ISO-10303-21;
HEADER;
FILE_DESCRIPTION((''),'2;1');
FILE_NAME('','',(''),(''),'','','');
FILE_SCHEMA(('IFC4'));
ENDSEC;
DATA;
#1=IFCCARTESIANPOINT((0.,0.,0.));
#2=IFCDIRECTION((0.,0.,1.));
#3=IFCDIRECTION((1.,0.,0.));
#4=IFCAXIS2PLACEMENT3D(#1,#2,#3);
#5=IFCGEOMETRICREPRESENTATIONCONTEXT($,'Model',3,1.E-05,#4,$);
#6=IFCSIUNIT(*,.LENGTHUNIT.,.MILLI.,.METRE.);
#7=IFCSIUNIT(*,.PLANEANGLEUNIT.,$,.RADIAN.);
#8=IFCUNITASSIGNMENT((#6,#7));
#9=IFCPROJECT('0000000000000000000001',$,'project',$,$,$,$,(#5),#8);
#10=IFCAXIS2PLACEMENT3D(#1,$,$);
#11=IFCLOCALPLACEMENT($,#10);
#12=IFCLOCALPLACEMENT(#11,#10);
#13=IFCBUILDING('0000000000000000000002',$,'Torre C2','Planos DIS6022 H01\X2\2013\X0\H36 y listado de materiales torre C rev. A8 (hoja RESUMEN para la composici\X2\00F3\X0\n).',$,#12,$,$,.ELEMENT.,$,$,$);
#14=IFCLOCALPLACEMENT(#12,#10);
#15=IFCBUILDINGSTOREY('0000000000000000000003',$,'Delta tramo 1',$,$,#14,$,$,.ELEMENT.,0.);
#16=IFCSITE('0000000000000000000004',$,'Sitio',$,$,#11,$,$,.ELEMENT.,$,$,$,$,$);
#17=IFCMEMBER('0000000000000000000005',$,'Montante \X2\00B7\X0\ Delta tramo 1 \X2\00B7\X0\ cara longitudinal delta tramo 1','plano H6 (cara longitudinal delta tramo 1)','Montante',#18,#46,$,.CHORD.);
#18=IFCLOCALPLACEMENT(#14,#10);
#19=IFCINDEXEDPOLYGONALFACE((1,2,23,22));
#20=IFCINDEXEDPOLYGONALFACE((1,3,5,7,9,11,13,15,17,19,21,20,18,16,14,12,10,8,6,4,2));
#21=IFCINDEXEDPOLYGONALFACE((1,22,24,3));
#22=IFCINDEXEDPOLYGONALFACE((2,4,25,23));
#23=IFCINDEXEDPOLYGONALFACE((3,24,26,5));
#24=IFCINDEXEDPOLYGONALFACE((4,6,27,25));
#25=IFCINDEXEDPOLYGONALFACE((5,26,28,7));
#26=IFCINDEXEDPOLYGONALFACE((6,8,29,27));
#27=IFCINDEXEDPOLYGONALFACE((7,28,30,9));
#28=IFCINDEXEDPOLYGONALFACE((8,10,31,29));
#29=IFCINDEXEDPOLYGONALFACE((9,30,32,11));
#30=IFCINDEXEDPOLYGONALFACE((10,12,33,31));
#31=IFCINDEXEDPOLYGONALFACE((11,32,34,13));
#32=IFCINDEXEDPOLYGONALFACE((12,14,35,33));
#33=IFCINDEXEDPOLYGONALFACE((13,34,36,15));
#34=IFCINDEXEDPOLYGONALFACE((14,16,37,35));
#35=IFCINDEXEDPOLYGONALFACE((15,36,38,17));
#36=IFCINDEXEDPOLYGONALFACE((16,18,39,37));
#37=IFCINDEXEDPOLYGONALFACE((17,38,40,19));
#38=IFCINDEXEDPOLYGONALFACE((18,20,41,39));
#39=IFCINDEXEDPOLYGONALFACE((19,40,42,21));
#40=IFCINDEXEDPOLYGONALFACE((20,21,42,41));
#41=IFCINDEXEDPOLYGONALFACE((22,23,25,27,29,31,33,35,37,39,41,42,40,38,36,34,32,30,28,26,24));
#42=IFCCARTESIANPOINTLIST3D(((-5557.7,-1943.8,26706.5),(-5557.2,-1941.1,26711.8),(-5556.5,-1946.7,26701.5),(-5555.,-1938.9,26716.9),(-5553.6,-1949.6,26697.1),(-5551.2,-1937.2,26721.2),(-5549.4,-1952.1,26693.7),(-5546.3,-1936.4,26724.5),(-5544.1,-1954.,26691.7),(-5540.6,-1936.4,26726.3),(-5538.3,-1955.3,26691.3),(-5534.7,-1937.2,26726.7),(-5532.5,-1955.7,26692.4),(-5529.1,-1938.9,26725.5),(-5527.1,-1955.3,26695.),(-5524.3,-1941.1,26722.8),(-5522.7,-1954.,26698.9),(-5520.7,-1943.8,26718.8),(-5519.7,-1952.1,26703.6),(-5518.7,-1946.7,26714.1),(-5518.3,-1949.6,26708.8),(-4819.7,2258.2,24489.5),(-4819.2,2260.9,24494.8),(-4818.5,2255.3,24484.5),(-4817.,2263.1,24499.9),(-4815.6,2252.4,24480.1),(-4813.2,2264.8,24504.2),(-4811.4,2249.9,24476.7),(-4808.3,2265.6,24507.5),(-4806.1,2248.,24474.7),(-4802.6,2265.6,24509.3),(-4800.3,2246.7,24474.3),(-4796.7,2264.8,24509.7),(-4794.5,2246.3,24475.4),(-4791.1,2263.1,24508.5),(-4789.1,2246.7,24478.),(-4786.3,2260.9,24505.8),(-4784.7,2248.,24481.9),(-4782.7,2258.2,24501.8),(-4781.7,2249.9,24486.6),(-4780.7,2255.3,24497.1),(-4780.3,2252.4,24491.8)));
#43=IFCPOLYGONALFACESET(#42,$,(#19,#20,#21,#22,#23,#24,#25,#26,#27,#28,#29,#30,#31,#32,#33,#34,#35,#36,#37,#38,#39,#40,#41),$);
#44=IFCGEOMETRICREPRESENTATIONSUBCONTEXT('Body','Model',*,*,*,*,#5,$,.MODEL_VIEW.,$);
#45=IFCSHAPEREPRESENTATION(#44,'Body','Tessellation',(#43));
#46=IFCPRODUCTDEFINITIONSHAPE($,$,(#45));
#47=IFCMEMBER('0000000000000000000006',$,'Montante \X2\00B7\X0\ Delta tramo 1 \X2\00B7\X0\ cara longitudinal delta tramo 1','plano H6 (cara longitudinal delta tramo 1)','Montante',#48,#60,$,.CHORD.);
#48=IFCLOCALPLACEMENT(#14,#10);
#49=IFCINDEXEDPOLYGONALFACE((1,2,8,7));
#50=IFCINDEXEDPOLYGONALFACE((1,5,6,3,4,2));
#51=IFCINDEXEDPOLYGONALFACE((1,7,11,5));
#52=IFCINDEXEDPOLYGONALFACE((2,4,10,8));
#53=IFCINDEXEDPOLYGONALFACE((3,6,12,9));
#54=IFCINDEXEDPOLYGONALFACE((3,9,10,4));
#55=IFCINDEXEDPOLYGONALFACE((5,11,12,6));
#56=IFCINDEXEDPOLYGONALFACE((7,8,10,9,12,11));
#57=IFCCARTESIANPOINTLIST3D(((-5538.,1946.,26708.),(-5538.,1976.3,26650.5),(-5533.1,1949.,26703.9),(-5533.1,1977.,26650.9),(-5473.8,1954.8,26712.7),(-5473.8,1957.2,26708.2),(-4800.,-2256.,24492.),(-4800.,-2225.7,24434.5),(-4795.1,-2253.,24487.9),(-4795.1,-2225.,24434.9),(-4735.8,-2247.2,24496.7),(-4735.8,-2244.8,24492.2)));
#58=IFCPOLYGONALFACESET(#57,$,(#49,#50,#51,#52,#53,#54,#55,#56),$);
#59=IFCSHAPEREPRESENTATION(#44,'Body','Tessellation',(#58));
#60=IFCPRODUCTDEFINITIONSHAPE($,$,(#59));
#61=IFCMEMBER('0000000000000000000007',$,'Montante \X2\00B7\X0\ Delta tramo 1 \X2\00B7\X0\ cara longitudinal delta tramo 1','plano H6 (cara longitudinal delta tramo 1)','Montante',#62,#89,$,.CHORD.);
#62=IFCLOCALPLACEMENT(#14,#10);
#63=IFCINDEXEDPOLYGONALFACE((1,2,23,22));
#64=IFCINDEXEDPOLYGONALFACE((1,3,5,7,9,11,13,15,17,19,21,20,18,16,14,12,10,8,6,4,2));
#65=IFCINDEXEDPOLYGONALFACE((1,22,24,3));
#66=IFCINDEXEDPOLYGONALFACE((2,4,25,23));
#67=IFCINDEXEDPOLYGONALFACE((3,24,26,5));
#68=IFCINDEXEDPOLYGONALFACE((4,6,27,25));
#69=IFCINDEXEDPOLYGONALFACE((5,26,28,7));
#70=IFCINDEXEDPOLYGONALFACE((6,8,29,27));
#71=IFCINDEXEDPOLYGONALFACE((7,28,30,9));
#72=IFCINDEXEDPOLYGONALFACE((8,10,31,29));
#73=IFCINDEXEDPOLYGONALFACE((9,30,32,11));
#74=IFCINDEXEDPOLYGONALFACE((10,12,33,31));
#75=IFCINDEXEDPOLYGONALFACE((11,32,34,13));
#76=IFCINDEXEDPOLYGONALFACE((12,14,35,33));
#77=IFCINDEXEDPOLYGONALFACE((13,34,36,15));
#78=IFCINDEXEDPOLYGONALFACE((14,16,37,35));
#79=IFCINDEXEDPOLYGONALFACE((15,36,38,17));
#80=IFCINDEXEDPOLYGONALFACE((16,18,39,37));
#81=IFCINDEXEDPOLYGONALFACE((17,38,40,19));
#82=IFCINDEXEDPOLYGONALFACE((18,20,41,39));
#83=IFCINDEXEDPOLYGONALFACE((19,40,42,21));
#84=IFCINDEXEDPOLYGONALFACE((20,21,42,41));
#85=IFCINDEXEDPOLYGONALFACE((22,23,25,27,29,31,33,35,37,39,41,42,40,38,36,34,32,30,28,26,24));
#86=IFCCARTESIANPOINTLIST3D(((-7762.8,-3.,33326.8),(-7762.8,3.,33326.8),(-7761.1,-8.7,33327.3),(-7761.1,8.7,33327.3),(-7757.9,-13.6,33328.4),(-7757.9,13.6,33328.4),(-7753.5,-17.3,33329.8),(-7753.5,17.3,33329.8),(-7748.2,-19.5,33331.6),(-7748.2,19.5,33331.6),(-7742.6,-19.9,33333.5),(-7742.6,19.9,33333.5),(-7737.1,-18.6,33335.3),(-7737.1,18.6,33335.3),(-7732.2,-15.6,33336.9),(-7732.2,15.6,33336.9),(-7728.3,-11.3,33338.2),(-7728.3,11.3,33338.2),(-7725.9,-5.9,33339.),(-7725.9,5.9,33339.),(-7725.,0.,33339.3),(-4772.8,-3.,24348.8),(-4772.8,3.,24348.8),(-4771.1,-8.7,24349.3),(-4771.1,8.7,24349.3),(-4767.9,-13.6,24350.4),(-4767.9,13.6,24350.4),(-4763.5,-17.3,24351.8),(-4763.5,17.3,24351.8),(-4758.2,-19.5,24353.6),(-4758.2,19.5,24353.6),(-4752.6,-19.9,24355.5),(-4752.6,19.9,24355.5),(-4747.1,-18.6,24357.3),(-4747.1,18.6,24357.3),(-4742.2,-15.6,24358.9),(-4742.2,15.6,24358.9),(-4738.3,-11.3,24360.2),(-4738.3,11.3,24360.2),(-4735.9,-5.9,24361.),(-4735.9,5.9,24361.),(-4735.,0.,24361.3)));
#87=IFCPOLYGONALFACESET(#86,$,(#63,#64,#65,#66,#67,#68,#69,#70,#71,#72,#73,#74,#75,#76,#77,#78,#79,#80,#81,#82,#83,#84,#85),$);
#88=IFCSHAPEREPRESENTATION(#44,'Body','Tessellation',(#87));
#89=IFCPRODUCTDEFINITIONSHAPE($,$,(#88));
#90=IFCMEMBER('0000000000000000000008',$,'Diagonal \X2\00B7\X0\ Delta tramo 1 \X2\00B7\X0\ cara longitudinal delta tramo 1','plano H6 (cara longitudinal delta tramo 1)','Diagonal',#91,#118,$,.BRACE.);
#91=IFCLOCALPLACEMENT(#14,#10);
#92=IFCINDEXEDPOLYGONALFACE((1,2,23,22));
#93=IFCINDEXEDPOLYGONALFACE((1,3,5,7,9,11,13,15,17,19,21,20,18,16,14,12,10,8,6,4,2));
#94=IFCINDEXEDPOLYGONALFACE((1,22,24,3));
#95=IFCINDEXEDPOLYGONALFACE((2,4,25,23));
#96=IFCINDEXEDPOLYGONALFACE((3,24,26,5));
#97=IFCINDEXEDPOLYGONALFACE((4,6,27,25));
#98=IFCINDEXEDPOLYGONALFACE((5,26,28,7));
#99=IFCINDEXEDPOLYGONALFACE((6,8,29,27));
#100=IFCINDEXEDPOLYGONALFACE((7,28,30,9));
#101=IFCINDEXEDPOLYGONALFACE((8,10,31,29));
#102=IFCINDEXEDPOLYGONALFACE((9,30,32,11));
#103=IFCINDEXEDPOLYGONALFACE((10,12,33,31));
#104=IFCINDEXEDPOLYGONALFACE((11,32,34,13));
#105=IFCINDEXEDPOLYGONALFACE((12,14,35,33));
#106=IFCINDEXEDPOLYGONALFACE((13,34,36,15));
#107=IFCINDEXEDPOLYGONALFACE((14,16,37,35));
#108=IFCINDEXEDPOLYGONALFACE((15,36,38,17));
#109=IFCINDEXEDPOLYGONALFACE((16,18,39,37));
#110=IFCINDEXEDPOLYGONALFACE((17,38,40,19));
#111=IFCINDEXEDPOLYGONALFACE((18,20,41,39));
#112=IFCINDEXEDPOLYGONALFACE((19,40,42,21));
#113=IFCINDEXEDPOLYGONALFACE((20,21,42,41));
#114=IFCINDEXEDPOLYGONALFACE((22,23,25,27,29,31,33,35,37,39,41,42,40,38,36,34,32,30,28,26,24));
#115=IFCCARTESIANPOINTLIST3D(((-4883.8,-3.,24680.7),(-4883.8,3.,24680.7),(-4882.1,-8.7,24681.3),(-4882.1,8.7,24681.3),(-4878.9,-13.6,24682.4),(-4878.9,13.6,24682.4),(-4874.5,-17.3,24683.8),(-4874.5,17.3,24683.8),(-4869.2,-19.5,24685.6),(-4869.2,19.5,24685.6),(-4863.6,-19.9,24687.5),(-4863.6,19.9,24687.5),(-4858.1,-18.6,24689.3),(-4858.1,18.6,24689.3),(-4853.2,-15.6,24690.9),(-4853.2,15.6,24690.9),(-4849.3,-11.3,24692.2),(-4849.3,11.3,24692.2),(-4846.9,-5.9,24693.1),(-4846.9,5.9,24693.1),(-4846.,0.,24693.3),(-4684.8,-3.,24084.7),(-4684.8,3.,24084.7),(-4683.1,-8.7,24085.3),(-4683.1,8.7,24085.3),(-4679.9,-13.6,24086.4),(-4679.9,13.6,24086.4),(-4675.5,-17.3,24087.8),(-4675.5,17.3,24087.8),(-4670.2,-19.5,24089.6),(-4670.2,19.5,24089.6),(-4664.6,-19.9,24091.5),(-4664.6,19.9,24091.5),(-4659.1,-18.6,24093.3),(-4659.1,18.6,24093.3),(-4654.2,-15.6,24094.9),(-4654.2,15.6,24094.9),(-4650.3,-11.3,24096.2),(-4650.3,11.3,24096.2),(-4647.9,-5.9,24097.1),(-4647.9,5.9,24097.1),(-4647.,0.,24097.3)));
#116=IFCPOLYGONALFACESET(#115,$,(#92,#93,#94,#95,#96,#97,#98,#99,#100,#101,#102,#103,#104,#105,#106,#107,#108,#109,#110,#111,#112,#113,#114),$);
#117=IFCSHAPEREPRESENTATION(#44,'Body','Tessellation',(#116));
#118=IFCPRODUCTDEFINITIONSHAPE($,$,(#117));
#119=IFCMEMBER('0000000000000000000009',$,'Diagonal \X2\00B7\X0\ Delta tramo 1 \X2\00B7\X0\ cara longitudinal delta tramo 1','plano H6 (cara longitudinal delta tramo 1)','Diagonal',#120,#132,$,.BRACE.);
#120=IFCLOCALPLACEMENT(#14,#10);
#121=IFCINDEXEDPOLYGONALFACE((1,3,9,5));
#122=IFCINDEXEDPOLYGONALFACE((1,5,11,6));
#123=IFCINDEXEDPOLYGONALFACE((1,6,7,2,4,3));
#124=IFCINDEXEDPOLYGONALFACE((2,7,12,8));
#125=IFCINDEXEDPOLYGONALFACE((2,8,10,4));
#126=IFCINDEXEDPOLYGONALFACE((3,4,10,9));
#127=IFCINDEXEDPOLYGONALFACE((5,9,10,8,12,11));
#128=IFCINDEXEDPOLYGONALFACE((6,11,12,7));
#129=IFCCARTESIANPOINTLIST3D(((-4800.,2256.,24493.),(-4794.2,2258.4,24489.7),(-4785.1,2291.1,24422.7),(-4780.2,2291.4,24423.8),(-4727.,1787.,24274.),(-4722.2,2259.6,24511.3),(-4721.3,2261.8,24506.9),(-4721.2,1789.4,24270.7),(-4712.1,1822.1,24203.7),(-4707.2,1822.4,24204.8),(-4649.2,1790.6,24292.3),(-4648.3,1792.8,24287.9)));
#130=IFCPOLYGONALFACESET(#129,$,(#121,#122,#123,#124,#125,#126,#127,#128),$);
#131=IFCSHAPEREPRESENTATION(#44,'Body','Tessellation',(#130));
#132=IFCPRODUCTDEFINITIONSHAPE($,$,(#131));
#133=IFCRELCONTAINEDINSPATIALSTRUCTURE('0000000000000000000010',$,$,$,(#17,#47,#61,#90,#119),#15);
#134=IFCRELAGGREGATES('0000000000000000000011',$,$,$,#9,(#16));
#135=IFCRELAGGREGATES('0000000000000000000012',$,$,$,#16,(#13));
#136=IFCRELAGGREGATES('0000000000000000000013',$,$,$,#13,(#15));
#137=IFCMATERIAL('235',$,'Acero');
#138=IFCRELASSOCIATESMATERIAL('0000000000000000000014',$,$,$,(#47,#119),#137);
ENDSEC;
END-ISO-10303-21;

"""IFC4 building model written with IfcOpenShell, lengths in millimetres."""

from ifc_helpers import new_model, si_unit, frame, frame_2d, origin, origin_with_axes, place, context, subcontext, project, spatial, circle, l_section, extrude, material, element, save


model = new_model("IFC4")

# Units and contexts
model_context = context("Model", 3, precision=1e-05, world=origin_with_axes())
body_context = subcontext(model_context, "Body", "Model", "MODEL_VIEW")
ifc_project = project(units=[si_unit("LENGTHUNIT", "METRE", prefix="MILLI"), si_unit("PLANEANGLEUNIT", "RADIAN")], contexts=[model_context])

# Site, building, storey
site_placement = place(None, origin())
site = spatial("IfcSite", under=ifc_project, at=site_placement, Name="Sitio", CompositionType="ELEMENT")
building_placement = place(site_placement, origin())
building = spatial("IfcBuilding", under=site, at=building_placement, Name="Torre C2", Description="Planos DIS6022 H01–H36 y listado de materiales torre C rev. A8 (hoja RESUMEN para la composición).", CompositionType="ELEMENT")
storey_placement = place(building_placement, origin())
storey = spatial("IfcBuildingStorey", under=building, at=storey_placement, Name="Delta tramo 1", CompositionType="ELEMENT", Elevation=0.0)

# Members
member_1_placement = place(storey_placement, frame((-4800.0, 2256.0, 24492.0), z_axis=(-0.153495, -0.873966, 0.46111), x_axis=(0.276036, -0.485987, -0.829229)))
element("IfcMember", 1, at=member_1_placement, inside=storey, Name="Montante · Delta tramo 1 · cara longitudinal delta tramo 1", Description="plano H6 (cara longitudinal delta tramo 1)", ObjectType="Montante", PredefinedType="CHORD", context=body_context, shape_type="SweptSolid", body=[
    extrude(circle(Radius=20.0), None, (0.0, 0.0, 1.0), 4808.0),
])
ifc_material_1 = material(Name="235", Category="Acero")
member_2_placement = place(storey_placement, frame((-4800.0, -2256.0, 24492.0), z_axis=(-0.15351, 0.87405, 0.460946), x_axis=(0.988147, 0.135785, 0.071609)))
element("IfcMember", 2, at=member_2_placement, inside=storey, material=ifc_material_1, Name="Montante · Delta tramo 1 · cara longitudinal delta tramo 1", Description="plano H6 (cara longitudinal delta tramo 1)", ObjectType="Montante", PredefinedType="CHORD", context=body_context, shape_type="SweptSolid", body=[
    extrude(l_section(Depth=65.0, Width=65.0, Thickness=5.0, at=frame_2d((32.5, 32.5))), None, (0.0, 0.0, 1.0), 4807.5),
])
member_3_placement = place(storey_placement, frame((-4754.0, 0.0, 24355.0), z_axis=(-0.315974, 0.0, 0.948768), x_axis=(0.948768, 0.0, 0.315974)))
element("IfcMember", 3, at=member_3_placement, inside=storey, Name="Montante · Delta tramo 1 · cara longitudinal delta tramo 1", Description="plano H6 (cara longitudinal delta tramo 1)", ObjectType="Montante", PredefinedType="CHORD", context=body_context, shape_type="SweptSolid", body=[
    extrude(circle(Radius=20.0), None, (0.0, 0.0, 1.0), 9462.8),
])
member_4_placement = place(storey_placement, frame((-4666.0, 0.0, 24091.0), z_axis=(-0.316705, 0.0, 0.948524), x_axis=(0.948524, 0.0, 0.316705)))
element("IfcMember", 4, at=member_4_placement, inside=storey, Name="Diagonal · Delta tramo 1 · cara longitudinal delta tramo 1", Description="plano H6 (cara longitudinal delta tramo 1)", ObjectType="Diagonal", PredefinedType="BRACE", context=body_context, shape_type="SweptSolid", body=[
    extrude(circle(Radius=20.0), None, (0.0, 0.0, 1.0), 628.3),
])
member_5_placement = place(storey_placement, frame((-4727.0, 1787.0, 24274.0), z_axis=(-0.13965, 0.897206, 0.418951), x_axis=(0.972489, 0.044604, 0.22864)))
element("IfcMember", 5, at=member_5_placement, inside=storey, material=ifc_material_1, Name="Diagonal · Delta tramo 1 · cara longitudinal delta tramo 1", Description="plano H6 (cara longitudinal delta tramo 1)", ObjectType="Diagonal", PredefinedType="BRACE", context=body_context, shape_type="SweptSolid", body=[
    extrude(l_section(Depth=80.0, Width=80.0, Thickness=5.0, at=frame_2d((40.0, 40.0))), None, (0.0, 0.0, 1.0), 522.7),
])

save(model, "model.ifc")
